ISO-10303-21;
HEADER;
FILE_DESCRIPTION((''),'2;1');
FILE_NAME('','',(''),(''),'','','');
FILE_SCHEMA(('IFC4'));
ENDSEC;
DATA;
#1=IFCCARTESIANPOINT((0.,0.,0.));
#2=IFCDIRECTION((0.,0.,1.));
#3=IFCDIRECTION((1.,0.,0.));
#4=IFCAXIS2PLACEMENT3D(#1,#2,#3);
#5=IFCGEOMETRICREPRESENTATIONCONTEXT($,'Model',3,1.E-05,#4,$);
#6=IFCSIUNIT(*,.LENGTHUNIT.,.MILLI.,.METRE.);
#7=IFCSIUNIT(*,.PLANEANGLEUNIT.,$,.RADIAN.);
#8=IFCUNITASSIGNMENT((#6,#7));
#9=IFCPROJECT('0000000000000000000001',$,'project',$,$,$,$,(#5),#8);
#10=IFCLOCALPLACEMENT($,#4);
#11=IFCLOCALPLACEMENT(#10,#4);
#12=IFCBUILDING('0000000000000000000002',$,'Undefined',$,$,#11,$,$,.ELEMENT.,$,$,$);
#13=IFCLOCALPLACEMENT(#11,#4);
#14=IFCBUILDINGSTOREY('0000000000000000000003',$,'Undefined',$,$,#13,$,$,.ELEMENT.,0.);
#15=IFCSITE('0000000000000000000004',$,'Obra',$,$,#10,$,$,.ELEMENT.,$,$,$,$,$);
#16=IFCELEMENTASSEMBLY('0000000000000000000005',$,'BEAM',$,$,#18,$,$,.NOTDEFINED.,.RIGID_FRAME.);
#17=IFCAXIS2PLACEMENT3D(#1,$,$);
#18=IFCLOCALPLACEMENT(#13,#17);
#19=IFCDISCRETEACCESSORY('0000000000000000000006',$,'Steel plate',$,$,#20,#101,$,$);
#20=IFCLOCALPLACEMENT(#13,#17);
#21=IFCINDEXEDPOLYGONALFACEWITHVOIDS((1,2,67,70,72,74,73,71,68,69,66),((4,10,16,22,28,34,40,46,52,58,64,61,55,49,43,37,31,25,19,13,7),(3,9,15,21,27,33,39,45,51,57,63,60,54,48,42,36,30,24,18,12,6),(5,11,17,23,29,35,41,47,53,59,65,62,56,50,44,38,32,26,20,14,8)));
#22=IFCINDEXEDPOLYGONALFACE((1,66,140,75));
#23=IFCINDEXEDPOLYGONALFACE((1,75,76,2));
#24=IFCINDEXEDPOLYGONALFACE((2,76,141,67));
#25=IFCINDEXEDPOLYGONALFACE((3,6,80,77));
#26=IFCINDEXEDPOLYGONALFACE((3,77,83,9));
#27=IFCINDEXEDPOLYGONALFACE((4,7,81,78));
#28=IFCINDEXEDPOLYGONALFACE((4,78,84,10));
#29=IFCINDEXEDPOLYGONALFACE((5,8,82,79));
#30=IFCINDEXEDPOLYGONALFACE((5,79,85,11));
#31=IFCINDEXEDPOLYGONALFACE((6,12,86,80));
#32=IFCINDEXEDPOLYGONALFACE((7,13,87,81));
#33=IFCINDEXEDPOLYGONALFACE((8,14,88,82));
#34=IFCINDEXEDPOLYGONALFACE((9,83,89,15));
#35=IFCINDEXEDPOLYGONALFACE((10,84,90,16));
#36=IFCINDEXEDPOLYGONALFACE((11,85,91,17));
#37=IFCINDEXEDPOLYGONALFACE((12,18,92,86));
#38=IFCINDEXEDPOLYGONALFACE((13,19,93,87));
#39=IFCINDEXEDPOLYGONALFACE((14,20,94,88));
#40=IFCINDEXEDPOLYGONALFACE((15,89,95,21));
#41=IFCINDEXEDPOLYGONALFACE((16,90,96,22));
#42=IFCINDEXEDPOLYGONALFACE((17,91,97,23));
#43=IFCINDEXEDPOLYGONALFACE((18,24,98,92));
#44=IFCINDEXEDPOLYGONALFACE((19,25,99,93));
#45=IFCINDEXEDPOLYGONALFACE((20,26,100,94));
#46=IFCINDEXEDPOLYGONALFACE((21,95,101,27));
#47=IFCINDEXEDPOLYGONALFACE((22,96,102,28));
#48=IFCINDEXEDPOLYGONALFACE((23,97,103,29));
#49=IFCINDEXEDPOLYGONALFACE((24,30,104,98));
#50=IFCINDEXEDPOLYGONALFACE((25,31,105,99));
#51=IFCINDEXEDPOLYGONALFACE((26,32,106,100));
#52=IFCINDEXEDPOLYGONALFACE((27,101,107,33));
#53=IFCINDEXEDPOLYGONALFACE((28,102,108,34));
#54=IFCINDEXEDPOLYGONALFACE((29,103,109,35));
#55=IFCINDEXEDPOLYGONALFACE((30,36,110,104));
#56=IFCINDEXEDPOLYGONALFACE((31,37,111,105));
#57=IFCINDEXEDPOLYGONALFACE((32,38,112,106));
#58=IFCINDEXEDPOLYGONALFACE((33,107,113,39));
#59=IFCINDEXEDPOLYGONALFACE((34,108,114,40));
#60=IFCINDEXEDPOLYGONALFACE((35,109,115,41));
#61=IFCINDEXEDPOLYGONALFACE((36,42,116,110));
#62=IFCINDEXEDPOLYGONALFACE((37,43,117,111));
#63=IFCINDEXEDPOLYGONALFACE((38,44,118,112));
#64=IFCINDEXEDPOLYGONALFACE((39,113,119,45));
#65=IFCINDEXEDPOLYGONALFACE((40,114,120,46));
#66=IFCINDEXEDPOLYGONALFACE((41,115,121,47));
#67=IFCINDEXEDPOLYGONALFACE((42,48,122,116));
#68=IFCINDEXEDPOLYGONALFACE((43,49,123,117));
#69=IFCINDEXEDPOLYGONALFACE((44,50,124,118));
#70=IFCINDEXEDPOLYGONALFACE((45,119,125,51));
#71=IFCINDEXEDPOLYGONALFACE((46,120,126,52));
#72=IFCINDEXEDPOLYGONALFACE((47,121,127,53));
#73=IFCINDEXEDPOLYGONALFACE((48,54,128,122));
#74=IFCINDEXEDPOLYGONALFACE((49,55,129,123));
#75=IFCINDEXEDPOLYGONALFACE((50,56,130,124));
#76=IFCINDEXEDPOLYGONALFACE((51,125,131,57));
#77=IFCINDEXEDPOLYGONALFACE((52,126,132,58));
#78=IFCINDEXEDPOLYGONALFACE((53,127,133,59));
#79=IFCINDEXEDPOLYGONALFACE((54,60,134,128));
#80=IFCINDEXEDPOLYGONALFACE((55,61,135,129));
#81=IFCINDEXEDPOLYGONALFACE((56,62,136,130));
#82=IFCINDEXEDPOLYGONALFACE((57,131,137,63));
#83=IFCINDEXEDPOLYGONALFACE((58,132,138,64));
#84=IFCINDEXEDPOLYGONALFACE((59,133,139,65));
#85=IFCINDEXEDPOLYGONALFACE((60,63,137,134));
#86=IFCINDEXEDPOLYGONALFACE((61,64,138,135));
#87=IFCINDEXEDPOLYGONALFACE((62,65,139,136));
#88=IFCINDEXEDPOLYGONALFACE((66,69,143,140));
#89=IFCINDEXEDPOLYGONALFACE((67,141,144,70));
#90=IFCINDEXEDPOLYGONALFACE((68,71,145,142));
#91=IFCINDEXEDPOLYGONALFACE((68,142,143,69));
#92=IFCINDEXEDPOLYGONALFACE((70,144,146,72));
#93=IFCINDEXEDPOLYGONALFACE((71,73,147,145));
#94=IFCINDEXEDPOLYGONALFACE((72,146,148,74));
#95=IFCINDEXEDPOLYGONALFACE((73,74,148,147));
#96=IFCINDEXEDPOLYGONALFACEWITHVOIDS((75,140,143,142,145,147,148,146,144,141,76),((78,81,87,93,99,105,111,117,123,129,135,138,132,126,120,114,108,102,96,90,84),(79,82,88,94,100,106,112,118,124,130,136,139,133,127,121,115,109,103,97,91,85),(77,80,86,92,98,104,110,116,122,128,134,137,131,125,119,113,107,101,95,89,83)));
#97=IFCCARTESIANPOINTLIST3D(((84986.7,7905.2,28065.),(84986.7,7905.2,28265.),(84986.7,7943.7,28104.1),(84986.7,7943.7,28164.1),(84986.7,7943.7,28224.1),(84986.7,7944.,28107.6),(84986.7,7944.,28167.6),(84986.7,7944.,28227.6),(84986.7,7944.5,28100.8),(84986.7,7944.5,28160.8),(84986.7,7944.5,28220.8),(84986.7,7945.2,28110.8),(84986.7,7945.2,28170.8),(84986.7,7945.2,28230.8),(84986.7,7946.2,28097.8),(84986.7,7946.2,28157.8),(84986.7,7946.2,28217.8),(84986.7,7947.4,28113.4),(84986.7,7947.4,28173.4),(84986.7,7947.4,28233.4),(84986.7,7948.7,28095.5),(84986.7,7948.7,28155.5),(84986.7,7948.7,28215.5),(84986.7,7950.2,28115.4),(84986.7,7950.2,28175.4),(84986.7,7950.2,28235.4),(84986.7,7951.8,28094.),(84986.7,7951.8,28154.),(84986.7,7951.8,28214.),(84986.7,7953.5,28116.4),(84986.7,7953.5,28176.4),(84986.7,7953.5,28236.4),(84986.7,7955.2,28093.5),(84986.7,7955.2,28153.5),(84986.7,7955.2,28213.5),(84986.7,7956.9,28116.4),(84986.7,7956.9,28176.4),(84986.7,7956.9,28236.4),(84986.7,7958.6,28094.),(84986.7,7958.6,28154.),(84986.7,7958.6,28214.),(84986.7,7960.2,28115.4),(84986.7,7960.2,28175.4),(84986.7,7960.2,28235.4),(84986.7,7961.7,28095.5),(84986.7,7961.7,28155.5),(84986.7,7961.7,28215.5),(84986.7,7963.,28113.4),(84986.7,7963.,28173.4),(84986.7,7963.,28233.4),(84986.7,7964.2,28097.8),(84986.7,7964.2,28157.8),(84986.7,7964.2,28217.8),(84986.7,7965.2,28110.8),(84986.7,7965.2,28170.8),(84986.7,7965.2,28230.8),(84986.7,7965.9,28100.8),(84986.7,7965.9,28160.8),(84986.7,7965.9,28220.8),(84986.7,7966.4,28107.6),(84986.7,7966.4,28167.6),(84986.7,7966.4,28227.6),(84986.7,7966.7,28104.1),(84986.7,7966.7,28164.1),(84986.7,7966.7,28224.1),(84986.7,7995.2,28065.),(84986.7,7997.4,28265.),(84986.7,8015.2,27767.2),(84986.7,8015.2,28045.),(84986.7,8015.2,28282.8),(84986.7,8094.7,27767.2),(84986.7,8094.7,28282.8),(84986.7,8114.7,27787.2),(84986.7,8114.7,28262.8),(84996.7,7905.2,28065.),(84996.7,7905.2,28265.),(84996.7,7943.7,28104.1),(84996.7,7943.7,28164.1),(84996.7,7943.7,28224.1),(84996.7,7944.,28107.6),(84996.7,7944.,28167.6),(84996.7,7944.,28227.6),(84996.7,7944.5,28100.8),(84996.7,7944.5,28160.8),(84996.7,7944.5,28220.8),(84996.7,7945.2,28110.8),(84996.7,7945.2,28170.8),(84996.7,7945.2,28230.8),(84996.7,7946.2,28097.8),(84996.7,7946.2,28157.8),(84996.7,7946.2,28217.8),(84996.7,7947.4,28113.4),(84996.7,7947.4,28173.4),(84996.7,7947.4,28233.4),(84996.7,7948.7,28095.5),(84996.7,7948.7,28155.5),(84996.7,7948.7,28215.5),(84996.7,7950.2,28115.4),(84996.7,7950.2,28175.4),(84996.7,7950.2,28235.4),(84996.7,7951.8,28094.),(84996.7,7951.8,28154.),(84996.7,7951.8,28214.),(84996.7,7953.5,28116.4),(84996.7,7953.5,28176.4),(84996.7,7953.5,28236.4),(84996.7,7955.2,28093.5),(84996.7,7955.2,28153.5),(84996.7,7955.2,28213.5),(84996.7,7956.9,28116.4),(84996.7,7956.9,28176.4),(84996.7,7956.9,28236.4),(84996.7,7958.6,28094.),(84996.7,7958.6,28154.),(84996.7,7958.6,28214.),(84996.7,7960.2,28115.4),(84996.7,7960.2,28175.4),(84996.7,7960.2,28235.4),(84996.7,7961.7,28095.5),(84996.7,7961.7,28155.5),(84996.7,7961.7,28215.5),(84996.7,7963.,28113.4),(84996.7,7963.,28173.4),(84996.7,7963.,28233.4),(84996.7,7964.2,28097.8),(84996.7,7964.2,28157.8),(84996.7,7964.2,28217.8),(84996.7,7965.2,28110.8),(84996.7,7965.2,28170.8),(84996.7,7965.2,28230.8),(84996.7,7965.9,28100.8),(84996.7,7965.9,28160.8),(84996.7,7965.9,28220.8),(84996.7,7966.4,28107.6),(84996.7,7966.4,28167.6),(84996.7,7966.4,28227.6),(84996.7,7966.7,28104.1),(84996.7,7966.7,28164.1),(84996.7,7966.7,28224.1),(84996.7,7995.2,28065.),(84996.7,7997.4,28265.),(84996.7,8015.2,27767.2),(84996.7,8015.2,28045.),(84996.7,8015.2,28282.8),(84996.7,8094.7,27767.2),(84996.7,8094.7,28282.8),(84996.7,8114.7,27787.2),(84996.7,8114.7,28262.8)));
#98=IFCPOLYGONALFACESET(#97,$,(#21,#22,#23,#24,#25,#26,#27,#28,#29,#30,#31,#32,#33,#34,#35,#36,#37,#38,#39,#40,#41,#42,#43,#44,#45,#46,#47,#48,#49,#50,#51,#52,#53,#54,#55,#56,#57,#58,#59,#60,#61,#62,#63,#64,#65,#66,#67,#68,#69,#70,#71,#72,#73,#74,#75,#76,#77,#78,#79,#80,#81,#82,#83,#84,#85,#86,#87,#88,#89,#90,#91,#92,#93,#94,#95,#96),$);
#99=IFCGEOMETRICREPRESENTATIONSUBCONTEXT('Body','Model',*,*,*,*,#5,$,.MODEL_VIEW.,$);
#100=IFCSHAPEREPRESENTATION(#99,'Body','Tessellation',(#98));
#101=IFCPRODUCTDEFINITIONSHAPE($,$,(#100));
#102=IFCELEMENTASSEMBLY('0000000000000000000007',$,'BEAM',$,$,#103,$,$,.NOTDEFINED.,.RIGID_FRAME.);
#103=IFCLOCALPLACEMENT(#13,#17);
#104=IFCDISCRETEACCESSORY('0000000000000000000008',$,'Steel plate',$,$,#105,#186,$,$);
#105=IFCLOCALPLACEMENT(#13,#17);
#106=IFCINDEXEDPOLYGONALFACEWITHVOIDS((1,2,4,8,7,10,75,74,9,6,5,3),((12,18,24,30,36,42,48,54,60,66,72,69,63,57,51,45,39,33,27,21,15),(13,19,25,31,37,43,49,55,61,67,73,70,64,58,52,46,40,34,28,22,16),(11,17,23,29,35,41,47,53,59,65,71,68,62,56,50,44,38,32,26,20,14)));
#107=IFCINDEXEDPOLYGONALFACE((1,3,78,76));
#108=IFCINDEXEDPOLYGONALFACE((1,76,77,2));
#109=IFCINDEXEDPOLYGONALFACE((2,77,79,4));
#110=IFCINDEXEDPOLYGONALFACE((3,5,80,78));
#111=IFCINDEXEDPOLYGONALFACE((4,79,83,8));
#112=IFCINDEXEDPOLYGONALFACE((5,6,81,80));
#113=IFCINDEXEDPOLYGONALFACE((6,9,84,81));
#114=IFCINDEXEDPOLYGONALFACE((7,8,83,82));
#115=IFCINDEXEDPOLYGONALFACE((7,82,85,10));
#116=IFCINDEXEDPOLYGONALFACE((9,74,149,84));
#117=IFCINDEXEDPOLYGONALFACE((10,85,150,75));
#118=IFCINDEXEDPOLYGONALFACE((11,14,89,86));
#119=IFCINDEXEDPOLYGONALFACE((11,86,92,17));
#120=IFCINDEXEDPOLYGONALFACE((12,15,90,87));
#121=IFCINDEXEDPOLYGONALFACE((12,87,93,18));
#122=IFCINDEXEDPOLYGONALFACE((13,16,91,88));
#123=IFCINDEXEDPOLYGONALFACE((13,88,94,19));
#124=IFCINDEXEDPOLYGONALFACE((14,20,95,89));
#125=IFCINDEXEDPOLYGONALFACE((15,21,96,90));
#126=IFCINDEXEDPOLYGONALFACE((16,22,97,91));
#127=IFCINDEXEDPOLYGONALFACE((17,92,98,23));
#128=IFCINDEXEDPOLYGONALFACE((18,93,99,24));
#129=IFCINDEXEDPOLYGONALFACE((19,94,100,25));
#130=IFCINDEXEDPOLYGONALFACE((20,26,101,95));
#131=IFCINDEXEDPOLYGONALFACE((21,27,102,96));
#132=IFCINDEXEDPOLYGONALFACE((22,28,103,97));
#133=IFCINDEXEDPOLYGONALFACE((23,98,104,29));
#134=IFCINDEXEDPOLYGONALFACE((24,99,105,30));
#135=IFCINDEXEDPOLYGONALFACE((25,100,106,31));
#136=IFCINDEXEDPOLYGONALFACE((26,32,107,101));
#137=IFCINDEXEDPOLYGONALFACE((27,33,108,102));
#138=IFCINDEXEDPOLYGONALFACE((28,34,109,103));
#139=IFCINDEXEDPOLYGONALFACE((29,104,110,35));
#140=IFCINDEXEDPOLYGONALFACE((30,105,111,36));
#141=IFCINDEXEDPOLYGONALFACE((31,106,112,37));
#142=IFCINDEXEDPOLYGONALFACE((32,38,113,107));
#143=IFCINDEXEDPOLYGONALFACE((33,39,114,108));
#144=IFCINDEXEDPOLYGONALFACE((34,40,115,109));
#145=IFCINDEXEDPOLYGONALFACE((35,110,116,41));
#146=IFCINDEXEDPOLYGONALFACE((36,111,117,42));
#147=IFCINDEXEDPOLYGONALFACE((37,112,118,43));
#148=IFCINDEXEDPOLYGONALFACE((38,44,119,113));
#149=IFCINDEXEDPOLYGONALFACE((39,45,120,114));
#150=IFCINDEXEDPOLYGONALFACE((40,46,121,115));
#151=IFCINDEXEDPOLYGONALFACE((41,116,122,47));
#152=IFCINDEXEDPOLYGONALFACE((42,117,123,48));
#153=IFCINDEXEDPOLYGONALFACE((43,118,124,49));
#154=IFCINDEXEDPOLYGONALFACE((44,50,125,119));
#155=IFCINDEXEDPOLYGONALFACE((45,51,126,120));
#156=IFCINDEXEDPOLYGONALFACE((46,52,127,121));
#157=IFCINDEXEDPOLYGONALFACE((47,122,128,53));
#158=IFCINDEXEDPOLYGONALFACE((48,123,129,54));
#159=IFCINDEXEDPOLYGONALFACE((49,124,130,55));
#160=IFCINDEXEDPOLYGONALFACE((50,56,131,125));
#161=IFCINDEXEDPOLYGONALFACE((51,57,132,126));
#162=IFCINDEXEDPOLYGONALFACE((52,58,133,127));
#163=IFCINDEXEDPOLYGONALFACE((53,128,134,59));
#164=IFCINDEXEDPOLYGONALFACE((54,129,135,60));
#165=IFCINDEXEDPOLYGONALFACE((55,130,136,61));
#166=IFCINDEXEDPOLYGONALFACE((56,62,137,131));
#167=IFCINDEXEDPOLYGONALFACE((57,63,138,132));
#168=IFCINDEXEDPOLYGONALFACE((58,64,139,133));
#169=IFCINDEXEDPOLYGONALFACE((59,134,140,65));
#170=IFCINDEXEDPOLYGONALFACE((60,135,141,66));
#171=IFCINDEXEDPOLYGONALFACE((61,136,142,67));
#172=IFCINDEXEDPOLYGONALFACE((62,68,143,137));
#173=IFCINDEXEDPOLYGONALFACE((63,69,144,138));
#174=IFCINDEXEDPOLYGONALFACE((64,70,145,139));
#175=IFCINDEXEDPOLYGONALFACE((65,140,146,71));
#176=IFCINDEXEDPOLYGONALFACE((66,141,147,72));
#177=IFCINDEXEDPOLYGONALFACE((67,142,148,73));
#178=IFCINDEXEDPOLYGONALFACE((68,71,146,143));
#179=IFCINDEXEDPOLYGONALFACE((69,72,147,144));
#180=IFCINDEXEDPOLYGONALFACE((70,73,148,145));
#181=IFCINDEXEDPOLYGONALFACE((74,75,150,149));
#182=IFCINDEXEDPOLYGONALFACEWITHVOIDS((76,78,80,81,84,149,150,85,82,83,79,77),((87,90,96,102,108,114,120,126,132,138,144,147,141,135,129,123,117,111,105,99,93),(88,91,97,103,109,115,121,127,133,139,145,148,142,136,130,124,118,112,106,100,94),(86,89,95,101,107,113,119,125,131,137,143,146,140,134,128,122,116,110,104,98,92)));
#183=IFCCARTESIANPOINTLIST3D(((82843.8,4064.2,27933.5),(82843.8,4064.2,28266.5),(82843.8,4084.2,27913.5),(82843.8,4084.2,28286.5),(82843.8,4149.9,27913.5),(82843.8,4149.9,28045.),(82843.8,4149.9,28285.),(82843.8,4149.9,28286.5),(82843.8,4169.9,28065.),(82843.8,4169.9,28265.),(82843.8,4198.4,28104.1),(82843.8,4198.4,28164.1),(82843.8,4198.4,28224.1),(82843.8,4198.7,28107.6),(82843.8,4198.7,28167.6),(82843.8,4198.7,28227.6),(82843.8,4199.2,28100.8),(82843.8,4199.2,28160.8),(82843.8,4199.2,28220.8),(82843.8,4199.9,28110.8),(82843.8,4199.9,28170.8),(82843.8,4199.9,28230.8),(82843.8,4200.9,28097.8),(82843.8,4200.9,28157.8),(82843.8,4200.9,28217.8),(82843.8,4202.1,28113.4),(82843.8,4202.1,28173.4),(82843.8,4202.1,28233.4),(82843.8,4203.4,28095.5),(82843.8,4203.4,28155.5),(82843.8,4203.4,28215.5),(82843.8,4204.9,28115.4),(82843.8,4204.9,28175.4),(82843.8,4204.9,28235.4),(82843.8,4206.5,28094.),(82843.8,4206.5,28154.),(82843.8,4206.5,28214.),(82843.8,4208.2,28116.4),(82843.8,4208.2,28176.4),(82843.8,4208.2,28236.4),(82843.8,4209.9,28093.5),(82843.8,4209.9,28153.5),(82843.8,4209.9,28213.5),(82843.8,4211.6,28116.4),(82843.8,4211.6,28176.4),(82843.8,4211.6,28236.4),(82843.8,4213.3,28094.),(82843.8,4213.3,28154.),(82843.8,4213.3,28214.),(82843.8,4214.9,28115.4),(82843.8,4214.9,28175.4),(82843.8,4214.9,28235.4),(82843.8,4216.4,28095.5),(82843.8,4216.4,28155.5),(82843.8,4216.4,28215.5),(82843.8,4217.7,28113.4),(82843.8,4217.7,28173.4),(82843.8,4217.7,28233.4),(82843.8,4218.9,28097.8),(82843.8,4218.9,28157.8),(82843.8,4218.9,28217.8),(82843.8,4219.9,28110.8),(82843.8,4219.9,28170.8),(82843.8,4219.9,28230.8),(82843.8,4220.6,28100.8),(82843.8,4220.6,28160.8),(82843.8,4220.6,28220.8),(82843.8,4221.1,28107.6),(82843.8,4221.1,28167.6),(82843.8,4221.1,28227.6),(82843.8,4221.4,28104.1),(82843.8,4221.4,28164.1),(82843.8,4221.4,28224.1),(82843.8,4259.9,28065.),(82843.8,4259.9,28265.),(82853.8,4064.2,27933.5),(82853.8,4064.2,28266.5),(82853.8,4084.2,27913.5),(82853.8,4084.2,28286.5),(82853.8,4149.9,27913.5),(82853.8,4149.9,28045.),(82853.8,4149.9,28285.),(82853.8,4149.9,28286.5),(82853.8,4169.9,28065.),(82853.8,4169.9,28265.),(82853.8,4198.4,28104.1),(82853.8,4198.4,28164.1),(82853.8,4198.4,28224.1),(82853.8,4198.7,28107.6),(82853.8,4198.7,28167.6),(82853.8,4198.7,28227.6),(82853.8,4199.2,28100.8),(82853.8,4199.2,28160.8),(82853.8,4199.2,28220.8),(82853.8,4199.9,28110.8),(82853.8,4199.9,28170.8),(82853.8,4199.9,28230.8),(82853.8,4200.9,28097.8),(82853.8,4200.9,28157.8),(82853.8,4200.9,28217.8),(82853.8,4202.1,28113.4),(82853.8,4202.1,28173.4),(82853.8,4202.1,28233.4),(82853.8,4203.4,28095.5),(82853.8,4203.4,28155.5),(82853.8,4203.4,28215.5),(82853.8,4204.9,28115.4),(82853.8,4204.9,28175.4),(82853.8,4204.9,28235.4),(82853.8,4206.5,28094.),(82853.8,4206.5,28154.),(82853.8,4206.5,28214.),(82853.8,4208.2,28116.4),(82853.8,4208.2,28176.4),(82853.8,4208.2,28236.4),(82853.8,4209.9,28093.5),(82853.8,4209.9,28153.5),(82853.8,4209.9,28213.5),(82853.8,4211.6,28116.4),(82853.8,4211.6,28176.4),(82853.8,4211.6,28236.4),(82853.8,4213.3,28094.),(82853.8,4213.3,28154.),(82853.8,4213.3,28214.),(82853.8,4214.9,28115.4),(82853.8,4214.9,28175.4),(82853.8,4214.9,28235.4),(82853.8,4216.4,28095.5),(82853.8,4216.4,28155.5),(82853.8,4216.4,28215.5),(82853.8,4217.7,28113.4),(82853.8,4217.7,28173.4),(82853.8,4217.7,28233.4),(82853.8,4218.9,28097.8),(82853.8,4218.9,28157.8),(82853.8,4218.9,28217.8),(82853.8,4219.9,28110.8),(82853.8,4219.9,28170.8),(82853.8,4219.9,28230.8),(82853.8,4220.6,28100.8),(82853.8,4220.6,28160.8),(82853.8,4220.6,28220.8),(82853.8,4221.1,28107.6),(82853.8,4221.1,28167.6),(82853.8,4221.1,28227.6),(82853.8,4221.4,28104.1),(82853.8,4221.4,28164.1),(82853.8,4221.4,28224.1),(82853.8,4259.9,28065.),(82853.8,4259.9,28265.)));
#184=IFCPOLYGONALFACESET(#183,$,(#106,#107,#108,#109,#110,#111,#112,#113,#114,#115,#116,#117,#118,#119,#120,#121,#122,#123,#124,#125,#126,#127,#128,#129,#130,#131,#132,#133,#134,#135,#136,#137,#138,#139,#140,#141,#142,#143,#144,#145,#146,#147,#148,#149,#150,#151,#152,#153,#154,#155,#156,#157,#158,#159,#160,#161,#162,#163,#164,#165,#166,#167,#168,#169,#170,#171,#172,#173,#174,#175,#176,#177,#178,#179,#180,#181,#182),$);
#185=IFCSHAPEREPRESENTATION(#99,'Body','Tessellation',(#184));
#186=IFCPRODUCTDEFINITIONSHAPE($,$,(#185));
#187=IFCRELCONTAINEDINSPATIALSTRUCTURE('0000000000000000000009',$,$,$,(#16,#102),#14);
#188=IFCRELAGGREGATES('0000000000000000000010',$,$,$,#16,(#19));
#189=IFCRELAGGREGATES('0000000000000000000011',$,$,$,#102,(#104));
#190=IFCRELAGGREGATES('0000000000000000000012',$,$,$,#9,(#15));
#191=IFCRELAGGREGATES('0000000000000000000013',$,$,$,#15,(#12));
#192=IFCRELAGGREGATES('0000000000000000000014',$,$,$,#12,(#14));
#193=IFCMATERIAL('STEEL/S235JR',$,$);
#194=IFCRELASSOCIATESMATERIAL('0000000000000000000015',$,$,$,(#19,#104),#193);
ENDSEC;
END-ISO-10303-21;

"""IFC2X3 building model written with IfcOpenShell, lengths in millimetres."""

from ifc_helpers import new_model, si_unit, frame, origin_with_axes, origin_2d_with_axis, place, context, subcontext, project, spatial, polyline, circle, outline, extrude, source, transform, mapped, material, element, aggregate, save


model = new_model("IFC2X3")

# Units and contexts
model_context = context("Model", 3, precision=1e-05, world=origin_with_axes())
body_context = subcontext(model_context, "Body", "Model", "MODEL_VIEW")
ifc_project = project(units=[si_unit("LENGTHUNIT", "METRE", prefix="MILLI"), si_unit("PLANEANGLEUNIT", "RADIAN")], contexts=[model_context])

# Site, building, storey
site_placement = place(None, origin_with_axes())
site = spatial("IfcSite", under=ifc_project, at=site_placement, Name="Obra", CompositionType="ELEMENT")
building_placement = place(site_placement, origin_with_axes())
building = spatial("IfcBuilding", under=site, at=building_placement, Name="Undefined", CompositionType="ELEMENT")
storey_placement = place(building_placement, origin_with_axes())
storey = spatial("IfcBuildingStorey", under=building, at=storey_placement, Name="Undefined", CompositionType="ELEMENT", Elevation=0.0)

# Shared definitions
ifc_material = material(Name="STEEL/S235JR")

# Element assembly, discrete accessory, opening
assembly_1_placement = place(storey_placement, origin_with_axes())
assembly_1 = element("IfcElementAssembly", 1, at=assembly_1_placement, inside=storey, Name="BEAM", AssemblyPlace="NOTDEFINED", PredefinedType="RIGID_FRAME")
discrete_accessory_1_placement = place(assembly_1_placement, frame((84991.7, 8114.7, 27787.2), z_axis=(-1.0, 0.000002, 0.0), x_axis=(0.0, -0.707107, -0.707107)))
discrete_accessory_1 = element("IfcDiscreteAccessory", 2, at=discrete_accessory_1_placement, material=ifc_material, Name="Steel plate", context=body_context, shape_type="SweptSolid", body=[
    extrude(outline(polyline([(0.0, 0.0), (28.3, 0.0), (84.5, 56.2), (-112.0, 252.6), (-112.0, 280.9), (-48.3, 344.5), (-189.8, 486.0), (-254.9, 420.8), (-280.1, 420.8), (-280.1, 420.8), (-336.3, 364.6), (-336.3, 336.3), (0.0, 0.0)])), frame((0.0, 0.0, -5.0), z_axis=(0.0, 0.0, 1.0), x_axis=(1.0, 0.0, 0.0)), (0.0, 0.0, 1.0), 10.0),
])
shared_shape_1 = source(origin_with_axes(), body_context, "Body", "SweptSolid", [
    extrude(circle(Radius=11.5, at=origin_2d_with_axis()), frame((0.0, -13.4, 0.0), z_axis=(0.0, 1.0, 0.0), x_axis=(1.0, 0.0, 0.0)), (0.0, 0.0, 1.0), 10.2),
])
opening_1_placement = place(assembly_1_placement, frame((85000.0, 8005.2, 28265.0), z_axis=(-0.000002, -1.0, 0.0), x_axis=(0.0, 0.0, -1.0)))
element("IfcOpeningElement", 3, at=opening_1_placement, cuts=discrete_accessory_1, ObjectType="Opening", context=body_context, shape_type="MappedRepresentation", body=[
    mapped(shared_shape_1, transform((40.0, 0.0, 50.0))),
    mapped(shared_shape_1, transform((100.0, 0.0, 50.0))),
    mapped(shared_shape_1, transform((160.0, 0.0, 50.0))),
])
aggregate(assembly_1, [discrete_accessory_1])

# Element assembly, discrete accessory, opening
assembly_2_placement = place(storey_placement, origin_with_axes())
assembly_2 = element("IfcElementAssembly", 4, at=assembly_2_placement, inside=storey, Name="BEAM", AssemblyPlace="NOTDEFINED", PredefinedType="RIGID_FRAME")
discrete_accessory_2_placement = place(assembly_2_placement, frame((82848.8, 4064.2, 27933.5), z_axis=(1.0, 0.0, 0.0), x_axis=(-0.000001, 0.707107, -0.707107)))
discrete_accessory_2 = element("IfcDiscreteAccessory", 5, at=discrete_accessory_2_placement, material=ifc_material, Name="Steel plate", context=body_context, shape_type="SweptSolid", body=[
    extrude(outline(polyline([(0.0, 0.0), (28.3, 0.0), (74.7, 46.5), (-18.2, 139.4), (-18.2, 167.7), (45.4, 231.4), (-96.0, 372.8), (-159.7, 309.1), (-187.9, 309.1), (-189.0, 310.2), (-235.5, 263.8), (-235.5, 235.5), (0.0, 0.0)])), frame((0.0, 0.0, -5.0), z_axis=(0.0, 0.0, 1.0), x_axis=(1.0, 0.0, 0.0)), (0.0, 0.0, 1.0), 10.0),
])
shared_shape_2 = source(origin_with_axes(), body_context, "Body", "SweptSolid", [
    extrude(circle(Radius=11.5, at=origin_2d_with_axis()), frame((0.0, -13.4, 0.0), z_axis=(0.0, 1.0, 0.0), x_axis=(1.0, 0.0, 0.0)), (0.0, 0.0, 1.0), 10.2),
])
opening_2_placement = place(assembly_2_placement, frame((82840.5, 4159.9, 28265.0), z_axis=(0.0, 1.0, 0.0), x_axis=(0.0, 0.0, -1.0)))
element("IfcOpeningElement", 6, at=opening_2_placement, cuts=discrete_accessory_2, ObjectType="Opening", context=body_context, shape_type="MappedRepresentation", body=[
    mapped(shared_shape_2, transform((40.0, 0.0, 50.0))),
    mapped(shared_shape_2, transform((100.0, 0.0, 50.0))),
    mapped(shared_shape_2, transform((160.0, 0.0, 50.0))),
])
aggregate(assembly_2, [discrete_accessory_2])

save(model, "model.ifc")
